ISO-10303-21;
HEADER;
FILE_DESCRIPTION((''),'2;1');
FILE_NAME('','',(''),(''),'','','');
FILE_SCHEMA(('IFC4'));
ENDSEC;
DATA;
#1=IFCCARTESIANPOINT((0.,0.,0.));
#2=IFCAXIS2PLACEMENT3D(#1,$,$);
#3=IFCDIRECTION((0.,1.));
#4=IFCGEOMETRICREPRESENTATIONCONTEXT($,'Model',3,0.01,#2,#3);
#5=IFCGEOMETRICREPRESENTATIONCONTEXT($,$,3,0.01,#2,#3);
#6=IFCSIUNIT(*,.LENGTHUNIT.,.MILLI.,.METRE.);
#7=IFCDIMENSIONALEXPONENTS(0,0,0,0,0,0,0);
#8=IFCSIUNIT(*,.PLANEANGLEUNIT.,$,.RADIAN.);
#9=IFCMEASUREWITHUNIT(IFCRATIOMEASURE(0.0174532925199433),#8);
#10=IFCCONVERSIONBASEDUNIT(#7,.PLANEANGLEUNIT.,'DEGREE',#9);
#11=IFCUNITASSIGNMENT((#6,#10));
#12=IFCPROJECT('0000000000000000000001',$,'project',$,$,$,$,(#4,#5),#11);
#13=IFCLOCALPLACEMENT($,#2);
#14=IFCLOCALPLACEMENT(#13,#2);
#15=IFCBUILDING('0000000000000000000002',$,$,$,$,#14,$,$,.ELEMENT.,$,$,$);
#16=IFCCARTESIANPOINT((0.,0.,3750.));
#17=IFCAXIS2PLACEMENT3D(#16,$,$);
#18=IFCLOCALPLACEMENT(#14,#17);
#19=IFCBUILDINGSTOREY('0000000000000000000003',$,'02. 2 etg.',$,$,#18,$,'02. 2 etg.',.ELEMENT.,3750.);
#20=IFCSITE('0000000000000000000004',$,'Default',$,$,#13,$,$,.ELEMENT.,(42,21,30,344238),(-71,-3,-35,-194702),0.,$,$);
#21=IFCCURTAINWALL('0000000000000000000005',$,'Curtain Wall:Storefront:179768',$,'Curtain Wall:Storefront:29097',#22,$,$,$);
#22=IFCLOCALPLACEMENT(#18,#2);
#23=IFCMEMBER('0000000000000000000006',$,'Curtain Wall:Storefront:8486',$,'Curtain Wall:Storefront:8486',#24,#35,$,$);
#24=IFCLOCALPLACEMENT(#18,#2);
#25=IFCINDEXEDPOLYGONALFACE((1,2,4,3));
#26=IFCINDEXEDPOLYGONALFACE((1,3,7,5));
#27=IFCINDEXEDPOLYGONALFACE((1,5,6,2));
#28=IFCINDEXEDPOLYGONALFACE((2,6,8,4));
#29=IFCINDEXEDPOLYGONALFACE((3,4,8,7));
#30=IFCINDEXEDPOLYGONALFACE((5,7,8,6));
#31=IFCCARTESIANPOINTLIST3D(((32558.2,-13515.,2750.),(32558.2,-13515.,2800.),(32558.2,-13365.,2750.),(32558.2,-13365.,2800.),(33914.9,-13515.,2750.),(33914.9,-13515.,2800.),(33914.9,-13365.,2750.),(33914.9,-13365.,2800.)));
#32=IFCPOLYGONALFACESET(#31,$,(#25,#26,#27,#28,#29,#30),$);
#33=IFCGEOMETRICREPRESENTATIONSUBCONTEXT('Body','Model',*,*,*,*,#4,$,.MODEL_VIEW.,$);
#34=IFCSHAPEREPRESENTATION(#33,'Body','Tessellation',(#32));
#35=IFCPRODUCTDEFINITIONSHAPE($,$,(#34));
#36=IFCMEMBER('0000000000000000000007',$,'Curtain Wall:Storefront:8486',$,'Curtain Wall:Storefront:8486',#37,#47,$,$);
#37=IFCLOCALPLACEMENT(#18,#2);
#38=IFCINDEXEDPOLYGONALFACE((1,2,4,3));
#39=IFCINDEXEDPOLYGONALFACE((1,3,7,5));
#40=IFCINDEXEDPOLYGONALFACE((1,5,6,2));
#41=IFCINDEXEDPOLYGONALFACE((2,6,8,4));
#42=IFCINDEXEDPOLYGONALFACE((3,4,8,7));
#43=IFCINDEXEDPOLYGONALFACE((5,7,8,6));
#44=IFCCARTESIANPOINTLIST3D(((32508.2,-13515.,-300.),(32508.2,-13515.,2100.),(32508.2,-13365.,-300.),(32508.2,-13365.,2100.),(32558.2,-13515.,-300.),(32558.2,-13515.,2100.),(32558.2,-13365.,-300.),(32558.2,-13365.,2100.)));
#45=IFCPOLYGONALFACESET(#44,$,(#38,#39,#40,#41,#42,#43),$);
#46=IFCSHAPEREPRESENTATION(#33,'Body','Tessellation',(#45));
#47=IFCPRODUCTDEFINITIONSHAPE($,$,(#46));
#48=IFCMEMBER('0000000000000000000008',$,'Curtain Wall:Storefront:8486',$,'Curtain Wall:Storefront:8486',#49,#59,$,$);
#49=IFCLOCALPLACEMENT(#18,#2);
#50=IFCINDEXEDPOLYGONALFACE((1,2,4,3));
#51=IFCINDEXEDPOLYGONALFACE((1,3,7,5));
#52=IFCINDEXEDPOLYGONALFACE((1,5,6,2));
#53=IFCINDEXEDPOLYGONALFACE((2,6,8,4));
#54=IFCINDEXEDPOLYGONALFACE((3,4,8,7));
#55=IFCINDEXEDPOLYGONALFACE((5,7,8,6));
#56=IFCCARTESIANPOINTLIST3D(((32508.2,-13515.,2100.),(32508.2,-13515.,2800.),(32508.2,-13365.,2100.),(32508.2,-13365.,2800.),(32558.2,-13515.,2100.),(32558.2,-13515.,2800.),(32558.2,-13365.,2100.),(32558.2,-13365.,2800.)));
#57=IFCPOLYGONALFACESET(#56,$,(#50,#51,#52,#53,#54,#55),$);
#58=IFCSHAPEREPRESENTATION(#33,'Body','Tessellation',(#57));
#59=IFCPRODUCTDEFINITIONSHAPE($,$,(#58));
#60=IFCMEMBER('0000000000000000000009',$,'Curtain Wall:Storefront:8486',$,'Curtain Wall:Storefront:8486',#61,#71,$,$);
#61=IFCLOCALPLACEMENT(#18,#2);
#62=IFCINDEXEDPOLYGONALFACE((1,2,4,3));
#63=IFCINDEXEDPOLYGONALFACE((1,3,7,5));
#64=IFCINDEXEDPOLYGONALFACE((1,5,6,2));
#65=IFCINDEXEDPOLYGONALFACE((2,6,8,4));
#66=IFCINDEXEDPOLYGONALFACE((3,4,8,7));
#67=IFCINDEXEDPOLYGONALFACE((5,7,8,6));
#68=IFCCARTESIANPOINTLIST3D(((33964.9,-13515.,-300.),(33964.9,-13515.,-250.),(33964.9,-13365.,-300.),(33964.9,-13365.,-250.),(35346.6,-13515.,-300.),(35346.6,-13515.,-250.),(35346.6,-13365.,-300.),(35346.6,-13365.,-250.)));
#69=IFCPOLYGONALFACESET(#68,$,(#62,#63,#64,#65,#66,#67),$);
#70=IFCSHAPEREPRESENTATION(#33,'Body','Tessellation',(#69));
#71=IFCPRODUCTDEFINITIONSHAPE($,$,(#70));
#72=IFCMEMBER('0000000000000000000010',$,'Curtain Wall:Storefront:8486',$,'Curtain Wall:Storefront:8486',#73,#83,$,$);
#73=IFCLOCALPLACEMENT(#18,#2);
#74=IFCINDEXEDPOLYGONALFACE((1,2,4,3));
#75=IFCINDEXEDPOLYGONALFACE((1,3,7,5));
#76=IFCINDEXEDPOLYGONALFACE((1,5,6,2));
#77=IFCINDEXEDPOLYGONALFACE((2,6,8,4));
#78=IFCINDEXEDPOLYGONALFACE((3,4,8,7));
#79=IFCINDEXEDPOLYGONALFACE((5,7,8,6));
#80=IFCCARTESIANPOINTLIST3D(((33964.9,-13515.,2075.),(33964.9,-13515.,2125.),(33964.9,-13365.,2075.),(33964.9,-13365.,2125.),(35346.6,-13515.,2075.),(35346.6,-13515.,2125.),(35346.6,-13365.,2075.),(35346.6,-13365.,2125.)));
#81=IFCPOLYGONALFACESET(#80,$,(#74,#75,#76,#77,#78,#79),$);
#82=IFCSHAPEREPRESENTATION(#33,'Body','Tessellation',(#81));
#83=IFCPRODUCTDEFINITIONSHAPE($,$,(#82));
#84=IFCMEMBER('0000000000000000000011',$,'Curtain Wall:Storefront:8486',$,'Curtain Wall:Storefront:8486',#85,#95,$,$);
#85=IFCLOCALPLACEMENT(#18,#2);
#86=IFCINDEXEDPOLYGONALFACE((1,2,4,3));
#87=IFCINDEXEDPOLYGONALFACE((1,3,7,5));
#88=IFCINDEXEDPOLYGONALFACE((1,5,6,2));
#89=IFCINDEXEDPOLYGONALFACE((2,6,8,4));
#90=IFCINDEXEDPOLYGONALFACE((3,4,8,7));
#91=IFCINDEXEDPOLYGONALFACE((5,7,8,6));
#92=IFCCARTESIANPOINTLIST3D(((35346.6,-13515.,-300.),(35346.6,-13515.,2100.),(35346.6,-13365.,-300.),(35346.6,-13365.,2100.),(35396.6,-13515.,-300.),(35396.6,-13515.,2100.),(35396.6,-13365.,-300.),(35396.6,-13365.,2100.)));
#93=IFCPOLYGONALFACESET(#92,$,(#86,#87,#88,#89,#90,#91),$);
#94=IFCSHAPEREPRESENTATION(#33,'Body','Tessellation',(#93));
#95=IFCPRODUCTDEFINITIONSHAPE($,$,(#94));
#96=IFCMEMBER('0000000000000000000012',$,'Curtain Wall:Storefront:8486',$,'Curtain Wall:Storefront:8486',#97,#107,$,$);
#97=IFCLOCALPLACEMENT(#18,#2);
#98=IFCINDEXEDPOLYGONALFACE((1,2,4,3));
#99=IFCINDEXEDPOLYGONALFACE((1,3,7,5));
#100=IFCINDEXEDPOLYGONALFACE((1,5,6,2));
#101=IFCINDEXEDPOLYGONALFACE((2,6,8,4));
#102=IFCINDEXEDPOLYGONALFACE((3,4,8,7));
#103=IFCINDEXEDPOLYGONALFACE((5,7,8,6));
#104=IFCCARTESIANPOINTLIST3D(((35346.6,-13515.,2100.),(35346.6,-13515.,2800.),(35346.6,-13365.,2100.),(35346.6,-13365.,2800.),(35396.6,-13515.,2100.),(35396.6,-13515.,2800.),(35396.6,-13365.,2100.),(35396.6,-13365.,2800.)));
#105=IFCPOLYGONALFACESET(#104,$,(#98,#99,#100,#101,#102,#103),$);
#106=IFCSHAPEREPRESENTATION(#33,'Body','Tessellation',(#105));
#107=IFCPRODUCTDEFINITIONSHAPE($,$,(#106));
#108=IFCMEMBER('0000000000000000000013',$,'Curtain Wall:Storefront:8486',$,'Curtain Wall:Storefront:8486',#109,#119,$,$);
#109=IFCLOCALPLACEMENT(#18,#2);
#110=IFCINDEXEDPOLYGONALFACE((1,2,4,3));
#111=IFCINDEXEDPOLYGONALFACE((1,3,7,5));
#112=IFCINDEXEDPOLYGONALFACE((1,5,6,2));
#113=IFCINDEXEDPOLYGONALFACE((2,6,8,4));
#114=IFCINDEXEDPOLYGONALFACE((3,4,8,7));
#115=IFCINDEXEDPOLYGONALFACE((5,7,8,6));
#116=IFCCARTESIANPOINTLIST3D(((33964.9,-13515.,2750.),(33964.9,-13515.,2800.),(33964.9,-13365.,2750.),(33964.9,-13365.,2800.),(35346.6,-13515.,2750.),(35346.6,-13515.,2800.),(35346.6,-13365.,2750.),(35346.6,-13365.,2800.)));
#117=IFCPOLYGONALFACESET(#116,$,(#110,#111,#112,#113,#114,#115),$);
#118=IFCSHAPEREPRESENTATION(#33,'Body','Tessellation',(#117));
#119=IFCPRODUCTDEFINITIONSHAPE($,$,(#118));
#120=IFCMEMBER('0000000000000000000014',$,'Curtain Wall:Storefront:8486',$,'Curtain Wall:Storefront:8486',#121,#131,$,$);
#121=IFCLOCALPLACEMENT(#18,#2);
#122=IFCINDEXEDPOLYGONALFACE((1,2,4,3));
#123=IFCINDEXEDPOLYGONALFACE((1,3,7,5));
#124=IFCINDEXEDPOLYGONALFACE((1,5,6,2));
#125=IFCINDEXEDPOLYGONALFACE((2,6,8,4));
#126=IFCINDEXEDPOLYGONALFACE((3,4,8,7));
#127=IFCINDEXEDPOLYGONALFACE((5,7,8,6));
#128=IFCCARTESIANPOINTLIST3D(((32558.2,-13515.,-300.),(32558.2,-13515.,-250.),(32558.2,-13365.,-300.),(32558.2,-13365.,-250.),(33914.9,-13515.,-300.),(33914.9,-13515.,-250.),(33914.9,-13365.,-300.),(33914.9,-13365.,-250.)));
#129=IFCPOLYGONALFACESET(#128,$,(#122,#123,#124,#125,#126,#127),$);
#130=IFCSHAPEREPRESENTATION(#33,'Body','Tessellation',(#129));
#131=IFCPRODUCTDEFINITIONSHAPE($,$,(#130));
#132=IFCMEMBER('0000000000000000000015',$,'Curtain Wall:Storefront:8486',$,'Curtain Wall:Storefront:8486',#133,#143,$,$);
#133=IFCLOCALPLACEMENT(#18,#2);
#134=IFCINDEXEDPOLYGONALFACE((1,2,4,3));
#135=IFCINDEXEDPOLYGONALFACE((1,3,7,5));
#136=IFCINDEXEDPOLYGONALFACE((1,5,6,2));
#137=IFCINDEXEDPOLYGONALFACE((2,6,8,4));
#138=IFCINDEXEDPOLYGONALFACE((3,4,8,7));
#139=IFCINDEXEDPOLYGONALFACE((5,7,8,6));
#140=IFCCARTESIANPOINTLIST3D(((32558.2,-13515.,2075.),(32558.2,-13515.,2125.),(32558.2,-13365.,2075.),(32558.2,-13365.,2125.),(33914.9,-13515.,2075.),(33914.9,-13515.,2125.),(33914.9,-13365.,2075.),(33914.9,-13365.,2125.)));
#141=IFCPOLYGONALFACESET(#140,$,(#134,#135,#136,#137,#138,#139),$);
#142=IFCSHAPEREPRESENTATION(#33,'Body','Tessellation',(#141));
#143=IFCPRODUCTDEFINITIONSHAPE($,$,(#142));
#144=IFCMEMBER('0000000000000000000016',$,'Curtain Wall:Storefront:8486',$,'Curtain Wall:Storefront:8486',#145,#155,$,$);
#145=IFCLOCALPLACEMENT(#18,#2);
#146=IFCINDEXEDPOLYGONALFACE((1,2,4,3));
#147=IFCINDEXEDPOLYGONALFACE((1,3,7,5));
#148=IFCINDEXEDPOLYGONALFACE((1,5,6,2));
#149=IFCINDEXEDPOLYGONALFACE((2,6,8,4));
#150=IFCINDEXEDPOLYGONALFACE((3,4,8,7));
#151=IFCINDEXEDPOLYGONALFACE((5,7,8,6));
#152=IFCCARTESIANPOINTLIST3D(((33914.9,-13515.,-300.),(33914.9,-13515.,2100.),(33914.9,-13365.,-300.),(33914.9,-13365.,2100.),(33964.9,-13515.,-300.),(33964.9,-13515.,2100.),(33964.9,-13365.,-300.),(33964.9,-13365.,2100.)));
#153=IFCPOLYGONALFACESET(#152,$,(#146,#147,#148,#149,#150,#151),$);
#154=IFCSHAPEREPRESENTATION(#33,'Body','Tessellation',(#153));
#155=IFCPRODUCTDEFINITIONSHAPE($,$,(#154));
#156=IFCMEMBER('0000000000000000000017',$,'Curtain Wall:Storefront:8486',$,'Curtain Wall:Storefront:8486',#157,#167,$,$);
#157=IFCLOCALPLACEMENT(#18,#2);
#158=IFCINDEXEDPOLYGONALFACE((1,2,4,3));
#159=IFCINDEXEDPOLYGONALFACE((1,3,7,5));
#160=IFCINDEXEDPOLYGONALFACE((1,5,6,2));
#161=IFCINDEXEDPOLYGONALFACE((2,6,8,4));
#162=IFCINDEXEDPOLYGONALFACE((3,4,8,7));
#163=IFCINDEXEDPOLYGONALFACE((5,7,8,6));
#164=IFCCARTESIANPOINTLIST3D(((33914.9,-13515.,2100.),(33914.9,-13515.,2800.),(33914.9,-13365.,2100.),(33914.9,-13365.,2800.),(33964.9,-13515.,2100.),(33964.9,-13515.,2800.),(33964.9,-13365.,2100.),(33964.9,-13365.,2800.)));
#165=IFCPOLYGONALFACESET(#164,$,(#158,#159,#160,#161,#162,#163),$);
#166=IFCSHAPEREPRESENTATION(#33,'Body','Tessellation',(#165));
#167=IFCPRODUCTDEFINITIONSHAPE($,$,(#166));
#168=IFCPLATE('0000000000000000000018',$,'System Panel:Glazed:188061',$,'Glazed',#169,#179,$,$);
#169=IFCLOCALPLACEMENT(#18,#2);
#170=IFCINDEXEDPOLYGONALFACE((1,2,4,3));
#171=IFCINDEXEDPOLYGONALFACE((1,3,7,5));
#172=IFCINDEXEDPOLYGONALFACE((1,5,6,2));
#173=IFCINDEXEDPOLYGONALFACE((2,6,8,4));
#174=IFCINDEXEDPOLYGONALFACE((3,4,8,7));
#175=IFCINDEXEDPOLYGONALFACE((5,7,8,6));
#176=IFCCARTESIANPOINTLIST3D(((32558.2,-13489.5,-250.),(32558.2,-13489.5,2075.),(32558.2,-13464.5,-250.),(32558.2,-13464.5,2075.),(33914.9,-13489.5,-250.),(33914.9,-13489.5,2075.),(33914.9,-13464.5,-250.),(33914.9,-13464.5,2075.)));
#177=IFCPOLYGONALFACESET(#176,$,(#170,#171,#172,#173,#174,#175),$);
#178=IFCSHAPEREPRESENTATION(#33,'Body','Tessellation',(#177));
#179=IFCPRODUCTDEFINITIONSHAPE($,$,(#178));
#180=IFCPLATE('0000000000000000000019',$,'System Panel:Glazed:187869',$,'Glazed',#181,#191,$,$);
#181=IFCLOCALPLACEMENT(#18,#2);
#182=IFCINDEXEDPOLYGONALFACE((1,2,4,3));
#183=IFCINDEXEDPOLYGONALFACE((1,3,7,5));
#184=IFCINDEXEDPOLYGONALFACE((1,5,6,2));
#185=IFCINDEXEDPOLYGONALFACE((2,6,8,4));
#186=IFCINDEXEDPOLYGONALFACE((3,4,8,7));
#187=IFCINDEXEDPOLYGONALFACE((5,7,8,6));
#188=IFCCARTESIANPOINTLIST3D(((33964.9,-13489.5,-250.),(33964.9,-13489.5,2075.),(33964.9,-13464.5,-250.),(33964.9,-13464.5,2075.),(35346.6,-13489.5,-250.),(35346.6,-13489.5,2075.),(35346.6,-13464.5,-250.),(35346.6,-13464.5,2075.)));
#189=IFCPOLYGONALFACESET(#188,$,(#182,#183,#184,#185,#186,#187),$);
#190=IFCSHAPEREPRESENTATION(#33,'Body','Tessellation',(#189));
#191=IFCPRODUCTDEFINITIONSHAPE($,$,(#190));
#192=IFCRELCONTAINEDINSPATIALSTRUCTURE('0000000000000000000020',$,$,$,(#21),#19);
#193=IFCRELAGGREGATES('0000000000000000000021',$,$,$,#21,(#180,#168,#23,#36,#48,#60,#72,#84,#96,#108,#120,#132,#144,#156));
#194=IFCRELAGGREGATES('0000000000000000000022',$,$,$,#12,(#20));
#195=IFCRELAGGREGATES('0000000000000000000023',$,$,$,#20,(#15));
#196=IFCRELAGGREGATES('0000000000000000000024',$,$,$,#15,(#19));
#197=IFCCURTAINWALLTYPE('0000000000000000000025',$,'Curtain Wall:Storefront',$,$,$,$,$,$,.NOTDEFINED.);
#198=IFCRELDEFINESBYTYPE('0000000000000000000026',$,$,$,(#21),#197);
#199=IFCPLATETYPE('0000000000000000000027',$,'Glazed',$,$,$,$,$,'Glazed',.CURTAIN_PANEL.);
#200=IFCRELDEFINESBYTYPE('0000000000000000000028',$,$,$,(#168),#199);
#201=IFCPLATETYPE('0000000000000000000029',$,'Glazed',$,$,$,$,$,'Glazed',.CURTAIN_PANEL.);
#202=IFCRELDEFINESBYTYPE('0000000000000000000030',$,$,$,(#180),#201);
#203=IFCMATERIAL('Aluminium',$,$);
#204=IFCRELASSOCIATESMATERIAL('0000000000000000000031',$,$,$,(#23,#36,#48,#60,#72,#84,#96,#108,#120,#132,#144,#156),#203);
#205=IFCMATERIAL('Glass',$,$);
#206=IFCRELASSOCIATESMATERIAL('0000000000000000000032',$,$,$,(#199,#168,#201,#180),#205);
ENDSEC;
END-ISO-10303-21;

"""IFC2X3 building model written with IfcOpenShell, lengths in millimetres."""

from ifc_helpers import new_model, entity, si_unit, converted_unit, direction, frame, frame_2d, origin, origin_2d_with_axis, place, context, subcontext, project, spatial, rectangle, extrude, source, transform, mapped, material, type_object, type_shapes, element, aggregate, save


model = new_model("IFC2X3")

# Units and contexts
model_context = context("Model", 3, precision=0.01, world=origin(), true_north=direction((0.0, 1.0)))
context_of_model = context(None, 3, precision=0.01, world=origin(), true_north=direction((0.0, 1.0)))
body_context = subcontext(model_context, "Body", "Model", "MODEL_VIEW")
ifc_project = project(units=[si_unit("LENGTHUNIT", "METRE", prefix="MILLI"), converted_unit("PLANEANGLEUNIT", "DEGREE", entity("IfcRatioMeasure", 0.0174532925199433), si_unit("PLANEANGLEUNIT", "RADIAN"), dimensions=[0, 0, 0, 0, 0, 0, 0])], contexts=[model_context, context_of_model])

# Site, building, storey
site_placement = place(None, origin())
site = spatial("IfcSite", under=ifc_project, at=site_placement, Name="Default", CompositionType="ELEMENT", RefLatitude=(42, 21, 30, 344238), RefLongitude=(-71, -3, -35, -194702), RefElevation=0.0)
building_placement = place(site_placement, origin())
building = spatial("IfcBuilding", under=site, at=building_placement, CompositionType="ELEMENT")
storey_placement = place(building_placement, frame((0.0, 0.0, 3750.0)))
storey = spatial("IfcBuildingStorey", under=building, at=storey_placement, Name="02. 2 etg.", LongName="02. 2 etg.", CompositionType="ELEMENT", Elevation=3750.0)

# Curtain wall, members, plates
curtain_wall_type = type_object("IfcCurtainWallType", Name="Curtain Wall:Storefront", PredefinedType="NOTDEFINED")
curtain_wall_placement = place(storey_placement, frame((0.0, 0.0, -3750.0)))
curtain_wall = element("IfcCurtainWall", 1, at=curtain_wall_placement, inside=storey, type_object=curtain_wall_type, Name="Curtain Wall:Storefront:179768", ObjectType="Curtain Wall:Storefront:29097")
ifc_material_1 = material(Name="Aluminium")
member_1_placement = place(curtain_wall_placement, frame((32558.2, -13515.0, 6500.0)))
member_1 = element("IfcMember", 2, at=member_1_placement, material=ifc_material_1, Name="Curtain Wall:Storefront:8486", ObjectType="Curtain Wall:Storefront:8486", context=body_context, shape_type="SweptSolid", body=[
    extrude(rectangle(XDim=1356.7, YDim=150.0, at=origin_2d_with_axis()), frame((678.3, 75.0, 0.0)), (0.0, 0.0, 1.0), 50.0),
])
member_2_placement = place(curtain_wall_placement, frame((32508.2, -13515.0, 3450.0)))
member_2 = element("IfcMember", 3, at=member_2_placement, material=ifc_material_1, Name="Curtain Wall:Storefront:8486", ObjectType="Curtain Wall:Storefront:8486", context=body_context, shape_type="SweptSolid", body=[
    extrude(rectangle(XDim=150.0, YDim=50.0, at=frame_2d((0.0, 0.0), x_axis=(1.0, 0.0))), frame((25.0, 75.0, 0.0), z_axis=(0.0, 0.0, 1.0), x_axis=(0.0, -1.0, 0.0)), (0.0, 0.0, 1.0), 2400.0),
])
member_3_placement = place(curtain_wall_placement, frame((32508.2, -13515.0, 5850.0)))
member_3 = element("IfcMember", 4, at=member_3_placement, material=ifc_material_1, Name="Curtain Wall:Storefront:8486", ObjectType="Curtain Wall:Storefront:8486", context=body_context, shape_type="SweptSolid", body=[
    extrude(rectangle(XDim=150.0, YDim=50.0, at=frame_2d((0.0, 0.0), x_axis=(1.0, 0.0))), frame((25.0, 75.0, 0.0), z_axis=(0.0, 0.0, 1.0), x_axis=(0.0, -1.0, 0.0)), (0.0, 0.0, 1.0), 700.0),
])
member_4_placement = place(curtain_wall_placement, frame((33964.9, -13515.0, 3450.0)))
member_4 = element("IfcMember", 5, at=member_4_placement, material=ifc_material_1, Name="Curtain Wall:Storefront:8486", ObjectType="Curtain Wall:Storefront:8486", context=body_context, shape_type="SweptSolid", body=[
    extrude(rectangle(XDim=1381.7, YDim=150.0, at=frame_2d((0.0, 0.0), x_axis=(1.0, 0.0))), frame((690.8, 75.0, 0.0), z_axis=(0.0, 0.0, 1.0), x_axis=(-1.0, 0.0, 0.0)), (0.0, 0.0, 1.0), 50.0),
])
member_5_placement = place(curtain_wall_placement, frame((33964.9, -13515.0, 5825.0)))
member_5 = element("IfcMember", 6, at=member_5_placement, material=ifc_material_1, Name="Curtain Wall:Storefront:8486", ObjectType="Curtain Wall:Storefront:8486", context=body_context, shape_type="SweptSolid", body=[
    extrude(rectangle(XDim=1381.7, YDim=150.0, at=frame_2d((0.0, 0.0), x_axis=(1.0, 0.0))), frame((690.8, 75.0, 0.0)), (0.0, 0.0, 1.0), 50.0),
])
member_6_placement = place(curtain_wall_placement, frame((35346.6, -13515.0, 3450.0)))
member_6 = element("IfcMember", 7, at=member_6_placement, material=ifc_material_1, Name="Curtain Wall:Storefront:8486", ObjectType="Curtain Wall:Storefront:8486", context=body_context, shape_type="SweptSolid", body=[
    extrude(rectangle(XDim=150.0, YDim=50.0, at=frame_2d((0.0, 0.0), x_axis=(1.0, 0.0))), frame((25.0, 75.0, 0.0), z_axis=(0.0, 0.0, 1.0), x_axis=(0.0, -1.0, 0.0)), (0.0, 0.0, 1.0), 2400.0),
])
member_7_placement = place(curtain_wall_placement, frame((35346.6, -13515.0, 5850.0)))
member_7 = element("IfcMember", 8, at=member_7_placement, material=ifc_material_1, Name="Curtain Wall:Storefront:8486", ObjectType="Curtain Wall:Storefront:8486", context=body_context, shape_type="SweptSolid", body=[
    extrude(rectangle(XDim=150.0, YDim=50.0, at=frame_2d((0.0, 0.0), x_axis=(1.0, 0.0))), frame((25.0, 75.0, 0.0), z_axis=(0.0, 0.0, 1.0), x_axis=(0.0, -1.0, 0.0)), (0.0, 0.0, 1.0), 700.0),
])
member_8_placement = place(curtain_wall_placement, frame((33964.9, -13515.0, 6500.0)))
member_8 = element("IfcMember", 9, at=member_8_placement, material=ifc_material_1, Name="Curtain Wall:Storefront:8486", ObjectType="Curtain Wall:Storefront:8486", context=body_context, shape_type="SweptSolid", body=[
    extrude(rectangle(XDim=1381.7, YDim=150.0, at=frame_2d((0.0, 0.0), x_axis=(1.0, 0.0))), frame((690.8, 75.0, 0.0)), (0.0, 0.0, 1.0), 50.0),
])
member_9_placement = place(curtain_wall_placement, frame((32558.2, -13515.0, 3450.0)))
member_9 = element("IfcMember", 10, at=member_9_placement, material=ifc_material_1, Name="Curtain Wall:Storefront:8486", ObjectType="Curtain Wall:Storefront:8486", context=body_context, shape_type="SweptSolid", body=[
    extrude(rectangle(XDim=1356.7, YDim=150.0, at=origin_2d_with_axis()), frame((678.3, 75.0, 0.0), z_axis=(0.0, 0.0, 1.0), x_axis=(-1.0, 0.0, 0.0)), (0.0, 0.0, 1.0), 50.0),
])
member_10_placement = place(curtain_wall_placement, frame((32558.2, -13515.0, 5825.0)))
member_10 = element("IfcMember", 11, at=member_10_placement, material=ifc_material_1, Name="Curtain Wall:Storefront:8486", ObjectType="Curtain Wall:Storefront:8486", context=body_context, shape_type="SweptSolid", body=[
    extrude(rectangle(XDim=1356.7, YDim=150.0, at=frame_2d((0.0, 0.0), x_axis=(1.0, 0.0))), frame((678.3, 75.0, 0.0)), (0.0, 0.0, 1.0), 50.0),
])
member_11_placement = place(curtain_wall_placement, frame((33914.9, -13515.0, 3450.0)))
member_11 = element("IfcMember", 12, at=member_11_placement, material=ifc_material_1, Name="Curtain Wall:Storefront:8486", ObjectType="Curtain Wall:Storefront:8486", context=body_context, shape_type="SweptSolid", body=[
    extrude(rectangle(XDim=150.0, YDim=50.0, at=frame_2d((0.0, 0.0), x_axis=(1.0, 0.0))), frame((25.0, 75.0, 0.0), z_axis=(0.0, 0.0, 1.0), x_axis=(0.0, -1.0, 0.0)), (0.0, 0.0, 1.0), 2400.0),
])
member_12_placement = place(curtain_wall_placement, frame((33914.9, -13515.0, 5850.0)))
member_12 = element("IfcMember", 13, at=member_12_placement, material=ifc_material_1, Name="Curtain Wall:Storefront:8486", ObjectType="Curtain Wall:Storefront:8486", context=body_context, shape_type="SweptSolid", body=[
    extrude(rectangle(XDim=150.0, YDim=50.0, at=frame_2d((0.0, 0.0), x_axis=(1.0, 0.0))), frame((25.0, 75.0, 0.0), z_axis=(0.0, 0.0, 1.0), x_axis=(0.0, -1.0, 0.0)), (0.0, 0.0, 1.0), 700.0),
])
ifc_material_2 = material(Name="Glass")
plate_type_1 = type_object("IfcPlateType", Name="Glazed", ElementType="Glazed", PredefinedType="CURTAIN_PANEL", material=ifc_material_2)
shared_shape_1 = source(origin(), body_context, "Body", "SweptSolid", [
    extrude(rectangle(XDim=25.0, YDim=1356.7, at=origin_2d_with_axis()), frame((678.3, 12.5, 0.0), z_axis=(0.0, 0.0, 1.0), x_axis=(0.0, 1.0, 0.0)), (0.0, 0.0, 1.0), 2325.0),
])
type_shapes(plate_type_1, [shared_shape_1])
plate_1_placement = place(curtain_wall_placement, frame((33914.9, -13464.5, 3500.0), z_axis=(0.0, 0.0, 1.0), x_axis=(-1.0, 0.0, 0.0)))
plate_1 = element("IfcPlate", 14, at=plate_1_placement, type_object=plate_type_1, material=ifc_material_2, Name="System Panel:Glazed:188061", ObjectType="Glazed", context=body_context, shape_type="MappedRepresentation", body=[
    mapped(shared_shape_1, transform((0.0, 0.0, 0.0), scale=1.0)),
])
plate_type_2 = type_object("IfcPlateType", Name="Glazed", ElementType="Glazed", PredefinedType="CURTAIN_PANEL", material=ifc_material_2)
shared_shape_2 = source(origin(), body_context, "Body", "SweptSolid", [
    extrude(rectangle(XDim=25.0, YDim=1381.7, at=origin_2d_with_axis()), frame((690.8, 12.5, 0.0), z_axis=(0.0, 0.0, 1.0), x_axis=(0.0, 1.0, 0.0)), (0.0, 0.0, 1.0), 2325.0),
])
type_shapes(plate_type_2, [shared_shape_2])
plate_2_placement = place(curtain_wall_placement, frame((35346.6, -13464.5, 3500.0), z_axis=(0.0, 0.0, 1.0), x_axis=(-1.0, 0.0, 0.0)))
plate_2 = element("IfcPlate", 15, at=plate_2_placement, type_object=plate_type_2, material=ifc_material_2, Name="System Panel:Glazed:187869", ObjectType="Glazed", context=body_context, shape_type="MappedRepresentation", body=[
    mapped(shared_shape_2, transform((0.0, 0.0, 0.0), scale=1.0)),
])
aggregate(curtain_wall, [plate_2, plate_1, member_1, member_2, member_3, member_4, member_5, member_6, member_7, member_8, member_9, member_10, member_11, member_12])

save(model, "model.ifc")
